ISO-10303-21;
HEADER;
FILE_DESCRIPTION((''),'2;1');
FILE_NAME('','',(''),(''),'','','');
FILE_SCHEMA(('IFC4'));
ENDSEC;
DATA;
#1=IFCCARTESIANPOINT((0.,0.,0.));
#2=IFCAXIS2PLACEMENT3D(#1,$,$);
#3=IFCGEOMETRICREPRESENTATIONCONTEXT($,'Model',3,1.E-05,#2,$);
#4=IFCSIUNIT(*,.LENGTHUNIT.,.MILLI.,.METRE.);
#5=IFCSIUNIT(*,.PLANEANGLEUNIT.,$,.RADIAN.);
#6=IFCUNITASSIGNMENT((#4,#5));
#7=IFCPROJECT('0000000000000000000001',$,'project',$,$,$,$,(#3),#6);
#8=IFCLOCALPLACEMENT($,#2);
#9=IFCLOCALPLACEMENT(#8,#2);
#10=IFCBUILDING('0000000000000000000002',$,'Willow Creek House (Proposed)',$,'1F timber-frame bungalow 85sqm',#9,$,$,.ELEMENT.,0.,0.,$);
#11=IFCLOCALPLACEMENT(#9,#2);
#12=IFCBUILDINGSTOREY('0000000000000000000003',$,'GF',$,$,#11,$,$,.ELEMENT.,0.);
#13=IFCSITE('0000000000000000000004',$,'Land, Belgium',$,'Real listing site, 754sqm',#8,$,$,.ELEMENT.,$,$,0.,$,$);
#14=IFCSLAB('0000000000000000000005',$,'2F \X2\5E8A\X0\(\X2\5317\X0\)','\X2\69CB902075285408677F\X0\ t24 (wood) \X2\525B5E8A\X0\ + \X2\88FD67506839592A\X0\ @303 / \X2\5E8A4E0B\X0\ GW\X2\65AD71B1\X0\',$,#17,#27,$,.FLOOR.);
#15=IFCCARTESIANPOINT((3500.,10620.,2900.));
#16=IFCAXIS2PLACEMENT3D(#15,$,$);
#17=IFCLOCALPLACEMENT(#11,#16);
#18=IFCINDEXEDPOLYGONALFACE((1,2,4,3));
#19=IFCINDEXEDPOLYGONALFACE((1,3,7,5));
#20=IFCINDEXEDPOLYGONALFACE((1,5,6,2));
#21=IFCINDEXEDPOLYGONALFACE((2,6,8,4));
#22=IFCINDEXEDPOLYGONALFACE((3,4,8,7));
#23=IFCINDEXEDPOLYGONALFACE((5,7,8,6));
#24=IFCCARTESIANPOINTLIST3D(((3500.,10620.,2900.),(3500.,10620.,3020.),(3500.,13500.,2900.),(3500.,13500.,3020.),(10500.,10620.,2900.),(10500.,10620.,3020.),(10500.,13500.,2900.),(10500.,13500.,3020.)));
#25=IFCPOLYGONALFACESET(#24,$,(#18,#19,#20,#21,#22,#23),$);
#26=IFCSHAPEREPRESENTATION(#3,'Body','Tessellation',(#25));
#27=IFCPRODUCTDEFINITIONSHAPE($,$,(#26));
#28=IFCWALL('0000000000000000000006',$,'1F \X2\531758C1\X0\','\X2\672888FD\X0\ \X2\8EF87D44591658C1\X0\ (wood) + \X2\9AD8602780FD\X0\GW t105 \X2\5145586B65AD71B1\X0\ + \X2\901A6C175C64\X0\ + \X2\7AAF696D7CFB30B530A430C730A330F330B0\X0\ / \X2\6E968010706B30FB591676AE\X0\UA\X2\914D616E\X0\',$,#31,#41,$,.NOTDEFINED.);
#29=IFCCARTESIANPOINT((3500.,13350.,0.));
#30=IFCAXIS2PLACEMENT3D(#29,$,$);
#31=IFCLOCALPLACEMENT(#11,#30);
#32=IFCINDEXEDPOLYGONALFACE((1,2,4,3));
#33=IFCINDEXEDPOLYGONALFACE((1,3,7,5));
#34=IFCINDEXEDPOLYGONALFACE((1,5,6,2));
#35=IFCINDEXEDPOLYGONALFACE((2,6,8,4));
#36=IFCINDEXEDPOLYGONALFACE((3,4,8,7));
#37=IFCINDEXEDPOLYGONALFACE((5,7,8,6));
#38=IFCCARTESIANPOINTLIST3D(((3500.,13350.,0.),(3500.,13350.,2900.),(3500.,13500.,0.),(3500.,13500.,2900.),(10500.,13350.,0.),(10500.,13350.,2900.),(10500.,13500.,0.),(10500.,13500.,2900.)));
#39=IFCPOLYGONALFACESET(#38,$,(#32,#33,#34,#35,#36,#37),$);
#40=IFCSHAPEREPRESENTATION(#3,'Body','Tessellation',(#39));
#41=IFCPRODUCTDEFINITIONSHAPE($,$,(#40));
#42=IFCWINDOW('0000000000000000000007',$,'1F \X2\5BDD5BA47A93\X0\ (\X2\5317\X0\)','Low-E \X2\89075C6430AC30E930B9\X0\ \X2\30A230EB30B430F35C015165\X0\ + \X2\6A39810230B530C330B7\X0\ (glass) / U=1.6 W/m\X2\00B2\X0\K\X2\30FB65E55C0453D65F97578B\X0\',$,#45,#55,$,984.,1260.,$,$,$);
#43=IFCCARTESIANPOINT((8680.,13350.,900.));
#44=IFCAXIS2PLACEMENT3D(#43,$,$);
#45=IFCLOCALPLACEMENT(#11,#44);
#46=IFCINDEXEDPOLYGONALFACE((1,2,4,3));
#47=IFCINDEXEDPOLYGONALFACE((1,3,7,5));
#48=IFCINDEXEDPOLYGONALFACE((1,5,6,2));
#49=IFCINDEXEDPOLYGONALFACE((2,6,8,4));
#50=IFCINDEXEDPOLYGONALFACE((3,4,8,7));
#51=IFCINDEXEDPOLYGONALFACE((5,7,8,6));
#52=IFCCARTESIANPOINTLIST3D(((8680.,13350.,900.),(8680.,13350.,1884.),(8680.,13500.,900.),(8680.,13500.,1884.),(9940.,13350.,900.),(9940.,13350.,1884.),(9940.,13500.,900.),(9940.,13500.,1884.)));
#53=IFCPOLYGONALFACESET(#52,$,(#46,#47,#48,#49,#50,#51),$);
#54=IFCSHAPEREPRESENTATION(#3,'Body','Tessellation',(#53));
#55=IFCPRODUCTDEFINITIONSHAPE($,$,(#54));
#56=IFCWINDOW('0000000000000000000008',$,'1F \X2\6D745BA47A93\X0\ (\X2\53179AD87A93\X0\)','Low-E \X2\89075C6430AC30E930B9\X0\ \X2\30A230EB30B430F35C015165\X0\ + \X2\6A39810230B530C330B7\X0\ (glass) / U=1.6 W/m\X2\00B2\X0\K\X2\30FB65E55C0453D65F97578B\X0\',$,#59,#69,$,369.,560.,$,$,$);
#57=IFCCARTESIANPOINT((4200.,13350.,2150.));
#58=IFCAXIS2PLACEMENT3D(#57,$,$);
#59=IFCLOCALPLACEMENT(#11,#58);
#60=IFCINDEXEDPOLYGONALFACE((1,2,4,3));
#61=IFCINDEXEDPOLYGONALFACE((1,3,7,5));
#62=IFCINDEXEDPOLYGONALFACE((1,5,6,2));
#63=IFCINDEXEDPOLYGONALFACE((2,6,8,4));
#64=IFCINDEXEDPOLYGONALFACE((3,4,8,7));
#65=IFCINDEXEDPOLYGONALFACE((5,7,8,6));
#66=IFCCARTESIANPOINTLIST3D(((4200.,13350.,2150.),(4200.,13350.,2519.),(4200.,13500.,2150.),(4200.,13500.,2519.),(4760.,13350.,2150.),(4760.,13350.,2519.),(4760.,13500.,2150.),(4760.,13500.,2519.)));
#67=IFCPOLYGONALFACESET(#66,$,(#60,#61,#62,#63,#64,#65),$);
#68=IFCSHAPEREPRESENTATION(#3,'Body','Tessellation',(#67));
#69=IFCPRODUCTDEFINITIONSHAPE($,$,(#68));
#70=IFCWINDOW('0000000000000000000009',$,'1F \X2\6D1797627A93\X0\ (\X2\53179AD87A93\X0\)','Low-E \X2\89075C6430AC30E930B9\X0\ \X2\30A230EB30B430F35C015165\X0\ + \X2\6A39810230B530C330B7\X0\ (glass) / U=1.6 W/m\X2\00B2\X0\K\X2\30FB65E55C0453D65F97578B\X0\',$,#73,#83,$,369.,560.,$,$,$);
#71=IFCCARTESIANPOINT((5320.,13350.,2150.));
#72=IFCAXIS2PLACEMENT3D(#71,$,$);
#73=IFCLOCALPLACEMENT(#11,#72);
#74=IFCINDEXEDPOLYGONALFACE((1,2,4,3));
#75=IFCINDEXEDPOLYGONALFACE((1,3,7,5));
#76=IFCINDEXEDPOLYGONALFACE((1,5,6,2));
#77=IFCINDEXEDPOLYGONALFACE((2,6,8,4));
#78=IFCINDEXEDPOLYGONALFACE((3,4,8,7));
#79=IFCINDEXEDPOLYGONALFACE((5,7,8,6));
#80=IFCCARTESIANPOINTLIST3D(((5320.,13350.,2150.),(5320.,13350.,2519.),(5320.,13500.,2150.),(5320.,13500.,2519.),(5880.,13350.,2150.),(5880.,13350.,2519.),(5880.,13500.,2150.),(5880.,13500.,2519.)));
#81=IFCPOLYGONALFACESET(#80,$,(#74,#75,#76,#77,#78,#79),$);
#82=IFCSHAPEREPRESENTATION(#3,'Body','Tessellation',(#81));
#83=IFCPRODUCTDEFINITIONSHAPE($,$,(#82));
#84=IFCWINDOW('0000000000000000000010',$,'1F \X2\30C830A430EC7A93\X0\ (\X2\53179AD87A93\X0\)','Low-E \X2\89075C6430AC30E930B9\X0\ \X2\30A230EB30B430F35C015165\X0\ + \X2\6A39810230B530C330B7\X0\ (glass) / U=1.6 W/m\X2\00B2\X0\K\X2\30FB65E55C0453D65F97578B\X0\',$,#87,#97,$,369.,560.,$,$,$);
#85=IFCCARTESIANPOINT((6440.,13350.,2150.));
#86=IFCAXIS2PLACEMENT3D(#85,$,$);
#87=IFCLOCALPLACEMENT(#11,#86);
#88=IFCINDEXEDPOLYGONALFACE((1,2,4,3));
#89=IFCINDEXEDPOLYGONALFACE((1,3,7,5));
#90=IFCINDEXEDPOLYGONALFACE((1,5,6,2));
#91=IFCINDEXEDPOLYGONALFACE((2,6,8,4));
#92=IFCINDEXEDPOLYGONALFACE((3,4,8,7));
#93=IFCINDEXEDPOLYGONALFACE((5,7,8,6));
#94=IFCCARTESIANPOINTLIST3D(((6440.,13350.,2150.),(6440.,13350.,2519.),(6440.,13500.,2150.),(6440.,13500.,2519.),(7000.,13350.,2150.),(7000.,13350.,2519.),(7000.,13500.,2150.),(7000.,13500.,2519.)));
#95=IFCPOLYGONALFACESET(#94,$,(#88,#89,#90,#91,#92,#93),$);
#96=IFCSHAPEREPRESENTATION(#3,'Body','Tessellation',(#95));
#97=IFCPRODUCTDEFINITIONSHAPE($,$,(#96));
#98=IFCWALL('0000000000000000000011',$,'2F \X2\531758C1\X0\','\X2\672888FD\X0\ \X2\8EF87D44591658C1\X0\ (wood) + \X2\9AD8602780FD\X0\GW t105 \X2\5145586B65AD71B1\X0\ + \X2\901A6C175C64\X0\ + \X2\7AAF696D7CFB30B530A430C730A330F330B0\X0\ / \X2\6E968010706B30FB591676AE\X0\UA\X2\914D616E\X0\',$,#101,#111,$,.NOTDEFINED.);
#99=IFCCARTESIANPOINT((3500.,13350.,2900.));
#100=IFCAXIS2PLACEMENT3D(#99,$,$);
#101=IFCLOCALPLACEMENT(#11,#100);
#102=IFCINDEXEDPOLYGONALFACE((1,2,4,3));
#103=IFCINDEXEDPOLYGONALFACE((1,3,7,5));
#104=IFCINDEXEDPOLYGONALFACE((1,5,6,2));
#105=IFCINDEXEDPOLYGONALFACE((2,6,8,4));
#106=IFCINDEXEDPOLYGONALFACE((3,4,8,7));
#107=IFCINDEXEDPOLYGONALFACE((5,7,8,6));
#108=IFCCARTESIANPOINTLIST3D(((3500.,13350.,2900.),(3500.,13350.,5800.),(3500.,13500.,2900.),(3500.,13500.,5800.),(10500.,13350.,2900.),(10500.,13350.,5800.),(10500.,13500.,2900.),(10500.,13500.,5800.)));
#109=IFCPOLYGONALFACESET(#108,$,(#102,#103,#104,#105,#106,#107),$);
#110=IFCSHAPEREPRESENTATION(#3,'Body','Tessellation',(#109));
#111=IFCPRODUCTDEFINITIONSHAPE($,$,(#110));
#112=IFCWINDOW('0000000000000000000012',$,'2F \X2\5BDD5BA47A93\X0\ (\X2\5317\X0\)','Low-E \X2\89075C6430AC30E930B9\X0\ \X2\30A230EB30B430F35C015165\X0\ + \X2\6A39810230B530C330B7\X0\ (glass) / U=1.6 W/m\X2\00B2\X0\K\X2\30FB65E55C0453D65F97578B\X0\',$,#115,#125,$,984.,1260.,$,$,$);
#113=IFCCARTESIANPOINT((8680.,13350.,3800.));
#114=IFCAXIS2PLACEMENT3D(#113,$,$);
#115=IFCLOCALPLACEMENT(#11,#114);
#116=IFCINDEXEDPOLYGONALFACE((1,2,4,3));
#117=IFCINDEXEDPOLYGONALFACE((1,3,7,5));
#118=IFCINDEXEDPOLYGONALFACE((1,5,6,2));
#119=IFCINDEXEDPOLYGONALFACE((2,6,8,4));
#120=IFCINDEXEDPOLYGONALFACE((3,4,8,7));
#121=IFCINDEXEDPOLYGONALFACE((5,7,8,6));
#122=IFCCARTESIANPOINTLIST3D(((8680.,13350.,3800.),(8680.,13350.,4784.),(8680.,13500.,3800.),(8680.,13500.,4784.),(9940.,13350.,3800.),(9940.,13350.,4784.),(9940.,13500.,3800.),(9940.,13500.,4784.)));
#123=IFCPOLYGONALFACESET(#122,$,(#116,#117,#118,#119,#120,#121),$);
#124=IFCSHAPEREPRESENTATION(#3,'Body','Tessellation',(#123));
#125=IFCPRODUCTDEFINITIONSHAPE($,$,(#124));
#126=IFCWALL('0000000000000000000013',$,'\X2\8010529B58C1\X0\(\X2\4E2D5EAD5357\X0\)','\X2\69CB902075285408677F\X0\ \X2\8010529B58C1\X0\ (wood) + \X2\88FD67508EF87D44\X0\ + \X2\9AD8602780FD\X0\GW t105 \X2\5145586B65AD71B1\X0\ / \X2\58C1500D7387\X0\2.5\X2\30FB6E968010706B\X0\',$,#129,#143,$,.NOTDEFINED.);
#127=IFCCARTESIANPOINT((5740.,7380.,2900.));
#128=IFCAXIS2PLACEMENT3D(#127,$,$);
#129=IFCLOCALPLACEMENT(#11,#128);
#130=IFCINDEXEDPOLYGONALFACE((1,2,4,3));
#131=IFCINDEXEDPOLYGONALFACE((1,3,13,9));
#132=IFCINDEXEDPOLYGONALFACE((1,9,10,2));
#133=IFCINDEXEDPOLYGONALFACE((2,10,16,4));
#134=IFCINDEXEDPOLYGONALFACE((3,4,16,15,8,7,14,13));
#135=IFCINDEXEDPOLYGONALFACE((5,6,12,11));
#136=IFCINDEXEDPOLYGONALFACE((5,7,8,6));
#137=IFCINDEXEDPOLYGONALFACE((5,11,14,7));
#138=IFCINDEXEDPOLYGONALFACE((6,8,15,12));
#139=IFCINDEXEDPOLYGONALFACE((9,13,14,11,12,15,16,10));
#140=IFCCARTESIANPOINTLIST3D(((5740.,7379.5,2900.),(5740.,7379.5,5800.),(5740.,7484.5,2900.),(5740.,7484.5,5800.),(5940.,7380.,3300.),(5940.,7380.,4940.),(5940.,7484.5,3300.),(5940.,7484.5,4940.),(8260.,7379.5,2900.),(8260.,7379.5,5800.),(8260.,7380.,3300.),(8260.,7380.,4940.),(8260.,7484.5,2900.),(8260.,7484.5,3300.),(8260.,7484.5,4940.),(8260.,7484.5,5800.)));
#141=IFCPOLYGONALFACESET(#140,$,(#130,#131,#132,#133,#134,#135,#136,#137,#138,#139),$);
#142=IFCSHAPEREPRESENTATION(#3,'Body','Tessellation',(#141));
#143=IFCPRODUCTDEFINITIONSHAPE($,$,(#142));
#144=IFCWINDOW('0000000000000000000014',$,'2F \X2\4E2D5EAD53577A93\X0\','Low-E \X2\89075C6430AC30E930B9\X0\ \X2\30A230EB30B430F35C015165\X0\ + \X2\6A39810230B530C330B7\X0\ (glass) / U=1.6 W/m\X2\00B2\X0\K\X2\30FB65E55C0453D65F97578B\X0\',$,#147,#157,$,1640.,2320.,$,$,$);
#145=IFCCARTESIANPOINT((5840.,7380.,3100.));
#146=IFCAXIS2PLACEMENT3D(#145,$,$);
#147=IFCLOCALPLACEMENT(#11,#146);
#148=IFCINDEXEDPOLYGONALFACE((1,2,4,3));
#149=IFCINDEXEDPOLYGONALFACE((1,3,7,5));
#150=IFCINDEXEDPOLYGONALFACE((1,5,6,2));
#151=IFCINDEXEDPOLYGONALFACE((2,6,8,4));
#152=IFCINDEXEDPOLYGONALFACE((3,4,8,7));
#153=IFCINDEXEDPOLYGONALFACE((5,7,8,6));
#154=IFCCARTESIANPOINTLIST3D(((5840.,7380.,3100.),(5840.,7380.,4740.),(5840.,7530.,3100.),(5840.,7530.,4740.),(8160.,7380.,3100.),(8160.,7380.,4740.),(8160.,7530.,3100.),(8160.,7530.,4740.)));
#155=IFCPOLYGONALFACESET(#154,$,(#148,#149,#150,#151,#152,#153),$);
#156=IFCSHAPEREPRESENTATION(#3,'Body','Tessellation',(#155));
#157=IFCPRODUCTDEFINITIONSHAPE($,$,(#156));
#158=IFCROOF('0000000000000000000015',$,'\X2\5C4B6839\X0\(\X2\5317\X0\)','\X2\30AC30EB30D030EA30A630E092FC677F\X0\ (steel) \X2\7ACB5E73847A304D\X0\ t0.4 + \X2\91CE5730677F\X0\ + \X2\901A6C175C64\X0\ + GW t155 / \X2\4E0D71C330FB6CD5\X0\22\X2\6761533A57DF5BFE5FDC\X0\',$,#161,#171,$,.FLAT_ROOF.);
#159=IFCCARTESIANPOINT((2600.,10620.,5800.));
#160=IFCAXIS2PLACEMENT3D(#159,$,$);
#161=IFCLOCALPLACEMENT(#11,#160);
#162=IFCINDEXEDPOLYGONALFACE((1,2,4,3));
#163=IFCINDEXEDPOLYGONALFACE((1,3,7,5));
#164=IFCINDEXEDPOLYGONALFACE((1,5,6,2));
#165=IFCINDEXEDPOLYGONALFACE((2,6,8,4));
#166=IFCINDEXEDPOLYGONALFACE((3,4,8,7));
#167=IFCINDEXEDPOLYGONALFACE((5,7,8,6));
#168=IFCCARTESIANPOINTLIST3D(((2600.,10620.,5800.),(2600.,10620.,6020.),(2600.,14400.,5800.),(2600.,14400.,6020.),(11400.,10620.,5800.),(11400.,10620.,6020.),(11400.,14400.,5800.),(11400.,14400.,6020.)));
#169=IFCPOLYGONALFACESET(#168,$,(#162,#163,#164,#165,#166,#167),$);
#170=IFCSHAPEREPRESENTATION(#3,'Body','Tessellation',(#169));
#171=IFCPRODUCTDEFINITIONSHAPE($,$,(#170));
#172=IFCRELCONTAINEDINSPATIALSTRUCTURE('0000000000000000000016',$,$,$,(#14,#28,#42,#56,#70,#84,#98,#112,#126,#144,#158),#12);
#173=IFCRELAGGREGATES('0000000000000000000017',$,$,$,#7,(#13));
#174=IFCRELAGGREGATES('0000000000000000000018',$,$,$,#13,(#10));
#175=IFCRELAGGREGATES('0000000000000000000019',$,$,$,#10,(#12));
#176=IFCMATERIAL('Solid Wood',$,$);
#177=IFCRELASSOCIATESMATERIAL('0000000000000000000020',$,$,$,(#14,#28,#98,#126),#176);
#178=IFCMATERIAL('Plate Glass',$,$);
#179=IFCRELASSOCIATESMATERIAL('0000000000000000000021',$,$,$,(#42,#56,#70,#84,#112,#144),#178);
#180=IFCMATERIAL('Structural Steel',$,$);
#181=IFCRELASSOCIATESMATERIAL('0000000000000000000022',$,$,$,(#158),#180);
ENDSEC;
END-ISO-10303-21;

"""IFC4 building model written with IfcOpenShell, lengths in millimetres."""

from ifc_helpers import new_model, si_unit, frame, frame_2d, origin, place, context, project, spatial, rectangle, extrude, material, element, fill, save


model = new_model("IFC4")

# Units and contexts
model_context = context("Model", 3, precision=1e-05, world=origin())
ifc_project = project(units=[si_unit("LENGTHUNIT", "METRE", prefix="MILLI"), si_unit("PLANEANGLEUNIT", "RADIAN")], contexts=[model_context])

# Site, building, storey
site_placement = place(None, origin())
site = spatial("IfcSite", under=ifc_project, at=site_placement, Name="Land, Belgium", ObjectType="Real listing site, 754sqm", CompositionType="ELEMENT", RefElevation=0.0)
building_placement = place(site_placement, origin())
building = spatial("IfcBuilding", under=site, at=building_placement, Name="Willow Creek House (Proposed)", ObjectType="1F timber-frame bungalow 85sqm", CompositionType="ELEMENT", ElevationOfRefHeight=0.0, ElevationOfTerrain=0.0)
storey_placement = place(building_placement, origin())
storey = spatial("IfcBuildingStorey", under=building, at=storey_placement, Name="GF", CompositionType="ELEMENT", Elevation=0.0)

# Slab
ifc_material_1 = material(Name="Solid Wood")
slab_1_placement = place(storey_placement, frame((3500.0, 10620.0, 2900.0)))
element("IfcSlab", 1, at=slab_1_placement, inside=storey, material=ifc_material_1, Name="2F 床(北)", Description="構造用合板 t24 (wood) 剛床 + 製材根太 @303 / 床下 GW断熱", PredefinedType="FLOOR", context=model_context, shape_type="SweptSolid", body=[
    extrude(rectangle(XDim=7000.0, YDim=2880.0, at=frame_2d((3500.0, 1440.0))), frame((3500.0, 10620.0, 2900.0)), (0.0, 0.0, 1.0), 120.0),
])

# Wall, openings, windows
wall_1_placement = place(storey_placement, frame((3500.0, 13350.0, 0.0)))
wall_1 = element("IfcWall", 2, at=wall_1_placement, inside=storey, material=ifc_material_1, Name="1F 北壁", Description="木製 軸組外壁 (wood) + 高性能GW t105 充填断熱 + 通気層 + 窯業系サイディング / 準耐火・外皮UA配慮", PredefinedType="NOTDEFINED", context=model_context, shape_type="SweptSolid", body=[
    extrude(rectangle(XDim=7000.0, YDim=150.0, at=frame_2d((3500.0, 75.0))), frame((3500.0, 13350.0, 0.0)), (0.0, 0.0, 1.0), 2900.0),
])
opening_1_placement = place(storey_placement, frame((8680.0, 13350.0, 900.0)))
opening_1 = element("IfcOpeningElement", 3, at=opening_1_placement, cuts=wall_1, PredefinedType="NOTDEFINED", context=model_context, shape_type="SweptSolid", body=[
    extrude(rectangle(XDim=1260.0, YDim=150.0, at=frame_2d((630.0, 75.0))), frame((8680.0, 13350.0, 900.0)), (0.0, 0.0, 1.0), 984.0),
])
opening_2_placement = place(storey_placement, frame((4200.0, 13350.0, 2150.0)))
opening_2 = element("IfcOpeningElement", 4, at=opening_2_placement, cuts=wall_1, PredefinedType="NOTDEFINED", context=model_context, shape_type="SweptSolid", body=[
    extrude(rectangle(XDim=560.0, YDim=150.0, at=frame_2d((280.0, 75.0))), frame((4200.0, 13350.0, 2150.0)), (0.0, 0.0, 1.0), 369.0),
])
opening_3_placement = place(storey_placement, frame((5320.0, 13350.0, 2150.0)))
opening_3 = element("IfcOpeningElement", 5, at=opening_3_placement, cuts=wall_1, PredefinedType="NOTDEFINED", context=model_context, shape_type="SweptSolid", body=[
    extrude(rectangle(XDim=560.0, YDim=150.0, at=frame_2d((280.0, 75.0))), frame((5320.0, 13350.0, 2150.0)), (0.0, 0.0, 1.0), 369.0),
])
opening_4_placement = place(storey_placement, frame((6440.0, 13350.0, 2150.0)))
opening_4 = element("IfcOpeningElement", 6, at=opening_4_placement, cuts=wall_1, PredefinedType="NOTDEFINED", context=model_context, shape_type="SweptSolid", body=[
    extrude(rectangle(XDim=560.0, YDim=150.0, at=frame_2d((280.0, 75.0))), frame((6440.0, 13350.0, 2150.0)), (0.0, 0.0, 1.0), 369.0),
])
ifc_material_2 = material(Name="Plate Glass")
window_1_placement = place(storey_placement, frame((8680.0, 13350.0, 900.0)))
window_1 = element("IfcWindow", 7, at=window_1_placement, inside=storey, material=ifc_material_2, Name="1F 寝室窓 (北)", Description="Low-E 複層ガラス アルゴン封入 + 樹脂サッシ (glass) / U=1.6 W/m²K・日射取得型", OverallHeight=984.0, OverallWidth=1260.0, context=model_context, shape_type="SweptSolid", body=[
    extrude(rectangle(XDim=1260.0, YDim=150.0, at=frame_2d((630.0, 75.0))), frame((8680.0, 13350.0, 900.0)), (0.0, 0.0, 1.0), 984.0),
])
fill(opening_1, window_1)
window_2_placement = place(storey_placement, frame((4200.0, 13350.0, 2150.0)))
window_2 = element("IfcWindow", 8, at=window_2_placement, inside=storey, material=ifc_material_2, Name="1F 浴室窓 (北高窓)", Description="Low-E 複層ガラス アルゴン封入 + 樹脂サッシ (glass) / U=1.6 W/m²K・日射取得型", OverallHeight=369.0, OverallWidth=560.0, context=model_context, shape_type="SweptSolid", body=[
    extrude(rectangle(XDim=560.0, YDim=150.0, at=frame_2d((280.0, 75.0))), frame((4200.0, 13350.0, 2150.0)), (0.0, 0.0, 1.0), 369.0),
])
fill(opening_2, window_2)
window_3_placement = place(storey_placement, frame((5320.0, 13350.0, 2150.0)))
window_3 = element("IfcWindow", 9, at=window_3_placement, inside=storey, material=ifc_material_2, Name="1F 洗面窓 (北高窓)", Description="Low-E 複層ガラス アルゴン封入 + 樹脂サッシ (glass) / U=1.6 W/m²K・日射取得型", OverallHeight=369.0, OverallWidth=560.0, context=model_context, shape_type="SweptSolid", body=[
    extrude(rectangle(XDim=560.0, YDim=150.0, at=frame_2d((280.0, 75.0))), frame((5320.0, 13350.0, 2150.0)), (0.0, 0.0, 1.0), 369.0),
])
fill(opening_3, window_3)
window_4_placement = place(storey_placement, frame((6440.0, 13350.0, 2150.0)))
window_4 = element("IfcWindow", 10, at=window_4_placement, inside=storey, material=ifc_material_2, Name="1F トイレ窓 (北高窓)", Description="Low-E 複層ガラス アルゴン封入 + 樹脂サッシ (glass) / U=1.6 W/m²K・日射取得型", OverallHeight=369.0, OverallWidth=560.0, context=model_context, shape_type="SweptSolid", body=[
    extrude(rectangle(XDim=560.0, YDim=150.0, at=frame_2d((280.0, 75.0))), frame((6440.0, 13350.0, 2150.0)), (0.0, 0.0, 1.0), 369.0),
])
fill(opening_4, window_4)

# Walls, openings, windows
wall_2_placement = place(storey_placement, frame((3500.0, 13350.0, 2900.0)))
wall_2 = element("IfcWall", 11, at=wall_2_placement, inside=storey, material=ifc_material_1, Name="2F 北壁", Description="木製 軸組外壁 (wood) + 高性能GW t105 充填断熱 + 通気層 + 窯業系サイディング / 準耐火・外皮UA配慮", PredefinedType="NOTDEFINED", context=model_context, shape_type="SweptSolid", body=[
    extrude(rectangle(XDim=7000.0, YDim=150.0, at=frame_2d((3500.0, 75.0))), frame((3500.0, 13350.0, 2900.0)), (0.0, 0.0, 1.0), 2900.0),
])
opening_5_placement = place(storey_placement, frame((8680.0, 13350.0, 3800.0)))
opening_5 = element("IfcOpeningElement", 12, at=opening_5_placement, cuts=wall_2, PredefinedType="NOTDEFINED", context=model_context, shape_type="SweptSolid", body=[
    extrude(rectangle(XDim=1260.0, YDim=150.0, at=frame_2d((630.0, 75.0))), frame((8680.0, 13350.0, 3800.0)), (0.0, 0.0, 1.0), 984.0),
])
window_5_placement = place(storey_placement, frame((8680.0, 13350.0, 3800.0)))
window_5 = element("IfcWindow", 13, at=window_5_placement, inside=storey, material=ifc_material_2, Name="2F 寝室窓 (北)", Description="Low-E 複層ガラス アルゴン封入 + 樹脂サッシ (glass) / U=1.6 W/m²K・日射取得型", OverallHeight=984.0, OverallWidth=1260.0, context=model_context, shape_type="SweptSolid", body=[
    extrude(rectangle(XDim=1260.0, YDim=150.0, at=frame_2d((630.0, 75.0))), frame((8680.0, 13350.0, 3800.0)), (0.0, 0.0, 1.0), 984.0),
])
fill(opening_5, window_5)
wall_3_placement = place(storey_placement, frame((5740.0, 7380.0, 2900.0)))
wall_3 = element("IfcWall", 14, at=wall_3_placement, inside=storey, material=ifc_material_1, Name="耐力壁(中庭南)", Description="構造用合板 耐力壁 (wood) + 製材軸組 + 高性能GW t105 充填断熱 / 壁倍率2.5・準耐火", PredefinedType="NOTDEFINED", context=model_context, shape_type="SweptSolid", body=[
    extrude(rectangle(XDim=2520.0, YDim=105.0, at=frame_2d((1260.0, 52.0))), frame((5740.0, 7380.0, 2900.0)), (0.0, 0.0, 1.0), 2900.0),
])
opening_6_placement = place(storey_placement, frame((5840.0, 7380.0, 3100.0)))
opening_6 = element("IfcOpeningElement", 15, at=opening_6_placement, cuts=wall_3, PredefinedType="NOTDEFINED", context=model_context, shape_type="SweptSolid", body=[
    extrude(rectangle(XDim=2320.0, YDim=150.0, at=frame_2d((1160.0, 75.0))), frame((5840.0, 7380.0, 3100.0)), (0.0, 0.0, 1.0), 1640.0),
])
window_6_placement = place(storey_placement, frame((5840.0, 7380.0, 3100.0)))
window_6 = element("IfcWindow", 16, at=window_6_placement, inside=storey, material=ifc_material_2, Name="2F 中庭南窓", Description="Low-E 複層ガラス アルゴン封入 + 樹脂サッシ (glass) / U=1.6 W/m²K・日射取得型", OverallHeight=1640.0, OverallWidth=2320.0, context=model_context, shape_type="SweptSolid", body=[
    extrude(rectangle(XDim=2320.0, YDim=150.0, at=frame_2d((1160.0, 75.0))), frame((5840.0, 7380.0, 3100.0)), (0.0, 0.0, 1.0), 1640.0),
])
fill(opening_6, window_6)

# Roof
ifc_material_3 = material(Name="Structural Steel")
for number, where, name in (
    (17, (2600.0, 10620.0, 5800.0), "屋根(北)"),
):
    element("IfcRoof", number, at=place(storey_placement, frame(where)), inside=storey, material=ifc_material_3, Name=name, Description="ガルバリウム鋼板 (steel) 立平葺き t0.4 + 野地板 + 通気層 + GW t155 / 不燃・法22条区域対応", PredefinedType="FLAT_ROOF", context=model_context, shape_type="SweptSolid", body=[
        extrude(rectangle(XDim=8800.0, YDim=3780.0, at=frame_2d((4400.0, 1890.0))), frame((2600.0, 10620.0, 5800.0)), (0.0, 0.0, 1.0), 220.0),
    ])

save(model, "model.ifc")
